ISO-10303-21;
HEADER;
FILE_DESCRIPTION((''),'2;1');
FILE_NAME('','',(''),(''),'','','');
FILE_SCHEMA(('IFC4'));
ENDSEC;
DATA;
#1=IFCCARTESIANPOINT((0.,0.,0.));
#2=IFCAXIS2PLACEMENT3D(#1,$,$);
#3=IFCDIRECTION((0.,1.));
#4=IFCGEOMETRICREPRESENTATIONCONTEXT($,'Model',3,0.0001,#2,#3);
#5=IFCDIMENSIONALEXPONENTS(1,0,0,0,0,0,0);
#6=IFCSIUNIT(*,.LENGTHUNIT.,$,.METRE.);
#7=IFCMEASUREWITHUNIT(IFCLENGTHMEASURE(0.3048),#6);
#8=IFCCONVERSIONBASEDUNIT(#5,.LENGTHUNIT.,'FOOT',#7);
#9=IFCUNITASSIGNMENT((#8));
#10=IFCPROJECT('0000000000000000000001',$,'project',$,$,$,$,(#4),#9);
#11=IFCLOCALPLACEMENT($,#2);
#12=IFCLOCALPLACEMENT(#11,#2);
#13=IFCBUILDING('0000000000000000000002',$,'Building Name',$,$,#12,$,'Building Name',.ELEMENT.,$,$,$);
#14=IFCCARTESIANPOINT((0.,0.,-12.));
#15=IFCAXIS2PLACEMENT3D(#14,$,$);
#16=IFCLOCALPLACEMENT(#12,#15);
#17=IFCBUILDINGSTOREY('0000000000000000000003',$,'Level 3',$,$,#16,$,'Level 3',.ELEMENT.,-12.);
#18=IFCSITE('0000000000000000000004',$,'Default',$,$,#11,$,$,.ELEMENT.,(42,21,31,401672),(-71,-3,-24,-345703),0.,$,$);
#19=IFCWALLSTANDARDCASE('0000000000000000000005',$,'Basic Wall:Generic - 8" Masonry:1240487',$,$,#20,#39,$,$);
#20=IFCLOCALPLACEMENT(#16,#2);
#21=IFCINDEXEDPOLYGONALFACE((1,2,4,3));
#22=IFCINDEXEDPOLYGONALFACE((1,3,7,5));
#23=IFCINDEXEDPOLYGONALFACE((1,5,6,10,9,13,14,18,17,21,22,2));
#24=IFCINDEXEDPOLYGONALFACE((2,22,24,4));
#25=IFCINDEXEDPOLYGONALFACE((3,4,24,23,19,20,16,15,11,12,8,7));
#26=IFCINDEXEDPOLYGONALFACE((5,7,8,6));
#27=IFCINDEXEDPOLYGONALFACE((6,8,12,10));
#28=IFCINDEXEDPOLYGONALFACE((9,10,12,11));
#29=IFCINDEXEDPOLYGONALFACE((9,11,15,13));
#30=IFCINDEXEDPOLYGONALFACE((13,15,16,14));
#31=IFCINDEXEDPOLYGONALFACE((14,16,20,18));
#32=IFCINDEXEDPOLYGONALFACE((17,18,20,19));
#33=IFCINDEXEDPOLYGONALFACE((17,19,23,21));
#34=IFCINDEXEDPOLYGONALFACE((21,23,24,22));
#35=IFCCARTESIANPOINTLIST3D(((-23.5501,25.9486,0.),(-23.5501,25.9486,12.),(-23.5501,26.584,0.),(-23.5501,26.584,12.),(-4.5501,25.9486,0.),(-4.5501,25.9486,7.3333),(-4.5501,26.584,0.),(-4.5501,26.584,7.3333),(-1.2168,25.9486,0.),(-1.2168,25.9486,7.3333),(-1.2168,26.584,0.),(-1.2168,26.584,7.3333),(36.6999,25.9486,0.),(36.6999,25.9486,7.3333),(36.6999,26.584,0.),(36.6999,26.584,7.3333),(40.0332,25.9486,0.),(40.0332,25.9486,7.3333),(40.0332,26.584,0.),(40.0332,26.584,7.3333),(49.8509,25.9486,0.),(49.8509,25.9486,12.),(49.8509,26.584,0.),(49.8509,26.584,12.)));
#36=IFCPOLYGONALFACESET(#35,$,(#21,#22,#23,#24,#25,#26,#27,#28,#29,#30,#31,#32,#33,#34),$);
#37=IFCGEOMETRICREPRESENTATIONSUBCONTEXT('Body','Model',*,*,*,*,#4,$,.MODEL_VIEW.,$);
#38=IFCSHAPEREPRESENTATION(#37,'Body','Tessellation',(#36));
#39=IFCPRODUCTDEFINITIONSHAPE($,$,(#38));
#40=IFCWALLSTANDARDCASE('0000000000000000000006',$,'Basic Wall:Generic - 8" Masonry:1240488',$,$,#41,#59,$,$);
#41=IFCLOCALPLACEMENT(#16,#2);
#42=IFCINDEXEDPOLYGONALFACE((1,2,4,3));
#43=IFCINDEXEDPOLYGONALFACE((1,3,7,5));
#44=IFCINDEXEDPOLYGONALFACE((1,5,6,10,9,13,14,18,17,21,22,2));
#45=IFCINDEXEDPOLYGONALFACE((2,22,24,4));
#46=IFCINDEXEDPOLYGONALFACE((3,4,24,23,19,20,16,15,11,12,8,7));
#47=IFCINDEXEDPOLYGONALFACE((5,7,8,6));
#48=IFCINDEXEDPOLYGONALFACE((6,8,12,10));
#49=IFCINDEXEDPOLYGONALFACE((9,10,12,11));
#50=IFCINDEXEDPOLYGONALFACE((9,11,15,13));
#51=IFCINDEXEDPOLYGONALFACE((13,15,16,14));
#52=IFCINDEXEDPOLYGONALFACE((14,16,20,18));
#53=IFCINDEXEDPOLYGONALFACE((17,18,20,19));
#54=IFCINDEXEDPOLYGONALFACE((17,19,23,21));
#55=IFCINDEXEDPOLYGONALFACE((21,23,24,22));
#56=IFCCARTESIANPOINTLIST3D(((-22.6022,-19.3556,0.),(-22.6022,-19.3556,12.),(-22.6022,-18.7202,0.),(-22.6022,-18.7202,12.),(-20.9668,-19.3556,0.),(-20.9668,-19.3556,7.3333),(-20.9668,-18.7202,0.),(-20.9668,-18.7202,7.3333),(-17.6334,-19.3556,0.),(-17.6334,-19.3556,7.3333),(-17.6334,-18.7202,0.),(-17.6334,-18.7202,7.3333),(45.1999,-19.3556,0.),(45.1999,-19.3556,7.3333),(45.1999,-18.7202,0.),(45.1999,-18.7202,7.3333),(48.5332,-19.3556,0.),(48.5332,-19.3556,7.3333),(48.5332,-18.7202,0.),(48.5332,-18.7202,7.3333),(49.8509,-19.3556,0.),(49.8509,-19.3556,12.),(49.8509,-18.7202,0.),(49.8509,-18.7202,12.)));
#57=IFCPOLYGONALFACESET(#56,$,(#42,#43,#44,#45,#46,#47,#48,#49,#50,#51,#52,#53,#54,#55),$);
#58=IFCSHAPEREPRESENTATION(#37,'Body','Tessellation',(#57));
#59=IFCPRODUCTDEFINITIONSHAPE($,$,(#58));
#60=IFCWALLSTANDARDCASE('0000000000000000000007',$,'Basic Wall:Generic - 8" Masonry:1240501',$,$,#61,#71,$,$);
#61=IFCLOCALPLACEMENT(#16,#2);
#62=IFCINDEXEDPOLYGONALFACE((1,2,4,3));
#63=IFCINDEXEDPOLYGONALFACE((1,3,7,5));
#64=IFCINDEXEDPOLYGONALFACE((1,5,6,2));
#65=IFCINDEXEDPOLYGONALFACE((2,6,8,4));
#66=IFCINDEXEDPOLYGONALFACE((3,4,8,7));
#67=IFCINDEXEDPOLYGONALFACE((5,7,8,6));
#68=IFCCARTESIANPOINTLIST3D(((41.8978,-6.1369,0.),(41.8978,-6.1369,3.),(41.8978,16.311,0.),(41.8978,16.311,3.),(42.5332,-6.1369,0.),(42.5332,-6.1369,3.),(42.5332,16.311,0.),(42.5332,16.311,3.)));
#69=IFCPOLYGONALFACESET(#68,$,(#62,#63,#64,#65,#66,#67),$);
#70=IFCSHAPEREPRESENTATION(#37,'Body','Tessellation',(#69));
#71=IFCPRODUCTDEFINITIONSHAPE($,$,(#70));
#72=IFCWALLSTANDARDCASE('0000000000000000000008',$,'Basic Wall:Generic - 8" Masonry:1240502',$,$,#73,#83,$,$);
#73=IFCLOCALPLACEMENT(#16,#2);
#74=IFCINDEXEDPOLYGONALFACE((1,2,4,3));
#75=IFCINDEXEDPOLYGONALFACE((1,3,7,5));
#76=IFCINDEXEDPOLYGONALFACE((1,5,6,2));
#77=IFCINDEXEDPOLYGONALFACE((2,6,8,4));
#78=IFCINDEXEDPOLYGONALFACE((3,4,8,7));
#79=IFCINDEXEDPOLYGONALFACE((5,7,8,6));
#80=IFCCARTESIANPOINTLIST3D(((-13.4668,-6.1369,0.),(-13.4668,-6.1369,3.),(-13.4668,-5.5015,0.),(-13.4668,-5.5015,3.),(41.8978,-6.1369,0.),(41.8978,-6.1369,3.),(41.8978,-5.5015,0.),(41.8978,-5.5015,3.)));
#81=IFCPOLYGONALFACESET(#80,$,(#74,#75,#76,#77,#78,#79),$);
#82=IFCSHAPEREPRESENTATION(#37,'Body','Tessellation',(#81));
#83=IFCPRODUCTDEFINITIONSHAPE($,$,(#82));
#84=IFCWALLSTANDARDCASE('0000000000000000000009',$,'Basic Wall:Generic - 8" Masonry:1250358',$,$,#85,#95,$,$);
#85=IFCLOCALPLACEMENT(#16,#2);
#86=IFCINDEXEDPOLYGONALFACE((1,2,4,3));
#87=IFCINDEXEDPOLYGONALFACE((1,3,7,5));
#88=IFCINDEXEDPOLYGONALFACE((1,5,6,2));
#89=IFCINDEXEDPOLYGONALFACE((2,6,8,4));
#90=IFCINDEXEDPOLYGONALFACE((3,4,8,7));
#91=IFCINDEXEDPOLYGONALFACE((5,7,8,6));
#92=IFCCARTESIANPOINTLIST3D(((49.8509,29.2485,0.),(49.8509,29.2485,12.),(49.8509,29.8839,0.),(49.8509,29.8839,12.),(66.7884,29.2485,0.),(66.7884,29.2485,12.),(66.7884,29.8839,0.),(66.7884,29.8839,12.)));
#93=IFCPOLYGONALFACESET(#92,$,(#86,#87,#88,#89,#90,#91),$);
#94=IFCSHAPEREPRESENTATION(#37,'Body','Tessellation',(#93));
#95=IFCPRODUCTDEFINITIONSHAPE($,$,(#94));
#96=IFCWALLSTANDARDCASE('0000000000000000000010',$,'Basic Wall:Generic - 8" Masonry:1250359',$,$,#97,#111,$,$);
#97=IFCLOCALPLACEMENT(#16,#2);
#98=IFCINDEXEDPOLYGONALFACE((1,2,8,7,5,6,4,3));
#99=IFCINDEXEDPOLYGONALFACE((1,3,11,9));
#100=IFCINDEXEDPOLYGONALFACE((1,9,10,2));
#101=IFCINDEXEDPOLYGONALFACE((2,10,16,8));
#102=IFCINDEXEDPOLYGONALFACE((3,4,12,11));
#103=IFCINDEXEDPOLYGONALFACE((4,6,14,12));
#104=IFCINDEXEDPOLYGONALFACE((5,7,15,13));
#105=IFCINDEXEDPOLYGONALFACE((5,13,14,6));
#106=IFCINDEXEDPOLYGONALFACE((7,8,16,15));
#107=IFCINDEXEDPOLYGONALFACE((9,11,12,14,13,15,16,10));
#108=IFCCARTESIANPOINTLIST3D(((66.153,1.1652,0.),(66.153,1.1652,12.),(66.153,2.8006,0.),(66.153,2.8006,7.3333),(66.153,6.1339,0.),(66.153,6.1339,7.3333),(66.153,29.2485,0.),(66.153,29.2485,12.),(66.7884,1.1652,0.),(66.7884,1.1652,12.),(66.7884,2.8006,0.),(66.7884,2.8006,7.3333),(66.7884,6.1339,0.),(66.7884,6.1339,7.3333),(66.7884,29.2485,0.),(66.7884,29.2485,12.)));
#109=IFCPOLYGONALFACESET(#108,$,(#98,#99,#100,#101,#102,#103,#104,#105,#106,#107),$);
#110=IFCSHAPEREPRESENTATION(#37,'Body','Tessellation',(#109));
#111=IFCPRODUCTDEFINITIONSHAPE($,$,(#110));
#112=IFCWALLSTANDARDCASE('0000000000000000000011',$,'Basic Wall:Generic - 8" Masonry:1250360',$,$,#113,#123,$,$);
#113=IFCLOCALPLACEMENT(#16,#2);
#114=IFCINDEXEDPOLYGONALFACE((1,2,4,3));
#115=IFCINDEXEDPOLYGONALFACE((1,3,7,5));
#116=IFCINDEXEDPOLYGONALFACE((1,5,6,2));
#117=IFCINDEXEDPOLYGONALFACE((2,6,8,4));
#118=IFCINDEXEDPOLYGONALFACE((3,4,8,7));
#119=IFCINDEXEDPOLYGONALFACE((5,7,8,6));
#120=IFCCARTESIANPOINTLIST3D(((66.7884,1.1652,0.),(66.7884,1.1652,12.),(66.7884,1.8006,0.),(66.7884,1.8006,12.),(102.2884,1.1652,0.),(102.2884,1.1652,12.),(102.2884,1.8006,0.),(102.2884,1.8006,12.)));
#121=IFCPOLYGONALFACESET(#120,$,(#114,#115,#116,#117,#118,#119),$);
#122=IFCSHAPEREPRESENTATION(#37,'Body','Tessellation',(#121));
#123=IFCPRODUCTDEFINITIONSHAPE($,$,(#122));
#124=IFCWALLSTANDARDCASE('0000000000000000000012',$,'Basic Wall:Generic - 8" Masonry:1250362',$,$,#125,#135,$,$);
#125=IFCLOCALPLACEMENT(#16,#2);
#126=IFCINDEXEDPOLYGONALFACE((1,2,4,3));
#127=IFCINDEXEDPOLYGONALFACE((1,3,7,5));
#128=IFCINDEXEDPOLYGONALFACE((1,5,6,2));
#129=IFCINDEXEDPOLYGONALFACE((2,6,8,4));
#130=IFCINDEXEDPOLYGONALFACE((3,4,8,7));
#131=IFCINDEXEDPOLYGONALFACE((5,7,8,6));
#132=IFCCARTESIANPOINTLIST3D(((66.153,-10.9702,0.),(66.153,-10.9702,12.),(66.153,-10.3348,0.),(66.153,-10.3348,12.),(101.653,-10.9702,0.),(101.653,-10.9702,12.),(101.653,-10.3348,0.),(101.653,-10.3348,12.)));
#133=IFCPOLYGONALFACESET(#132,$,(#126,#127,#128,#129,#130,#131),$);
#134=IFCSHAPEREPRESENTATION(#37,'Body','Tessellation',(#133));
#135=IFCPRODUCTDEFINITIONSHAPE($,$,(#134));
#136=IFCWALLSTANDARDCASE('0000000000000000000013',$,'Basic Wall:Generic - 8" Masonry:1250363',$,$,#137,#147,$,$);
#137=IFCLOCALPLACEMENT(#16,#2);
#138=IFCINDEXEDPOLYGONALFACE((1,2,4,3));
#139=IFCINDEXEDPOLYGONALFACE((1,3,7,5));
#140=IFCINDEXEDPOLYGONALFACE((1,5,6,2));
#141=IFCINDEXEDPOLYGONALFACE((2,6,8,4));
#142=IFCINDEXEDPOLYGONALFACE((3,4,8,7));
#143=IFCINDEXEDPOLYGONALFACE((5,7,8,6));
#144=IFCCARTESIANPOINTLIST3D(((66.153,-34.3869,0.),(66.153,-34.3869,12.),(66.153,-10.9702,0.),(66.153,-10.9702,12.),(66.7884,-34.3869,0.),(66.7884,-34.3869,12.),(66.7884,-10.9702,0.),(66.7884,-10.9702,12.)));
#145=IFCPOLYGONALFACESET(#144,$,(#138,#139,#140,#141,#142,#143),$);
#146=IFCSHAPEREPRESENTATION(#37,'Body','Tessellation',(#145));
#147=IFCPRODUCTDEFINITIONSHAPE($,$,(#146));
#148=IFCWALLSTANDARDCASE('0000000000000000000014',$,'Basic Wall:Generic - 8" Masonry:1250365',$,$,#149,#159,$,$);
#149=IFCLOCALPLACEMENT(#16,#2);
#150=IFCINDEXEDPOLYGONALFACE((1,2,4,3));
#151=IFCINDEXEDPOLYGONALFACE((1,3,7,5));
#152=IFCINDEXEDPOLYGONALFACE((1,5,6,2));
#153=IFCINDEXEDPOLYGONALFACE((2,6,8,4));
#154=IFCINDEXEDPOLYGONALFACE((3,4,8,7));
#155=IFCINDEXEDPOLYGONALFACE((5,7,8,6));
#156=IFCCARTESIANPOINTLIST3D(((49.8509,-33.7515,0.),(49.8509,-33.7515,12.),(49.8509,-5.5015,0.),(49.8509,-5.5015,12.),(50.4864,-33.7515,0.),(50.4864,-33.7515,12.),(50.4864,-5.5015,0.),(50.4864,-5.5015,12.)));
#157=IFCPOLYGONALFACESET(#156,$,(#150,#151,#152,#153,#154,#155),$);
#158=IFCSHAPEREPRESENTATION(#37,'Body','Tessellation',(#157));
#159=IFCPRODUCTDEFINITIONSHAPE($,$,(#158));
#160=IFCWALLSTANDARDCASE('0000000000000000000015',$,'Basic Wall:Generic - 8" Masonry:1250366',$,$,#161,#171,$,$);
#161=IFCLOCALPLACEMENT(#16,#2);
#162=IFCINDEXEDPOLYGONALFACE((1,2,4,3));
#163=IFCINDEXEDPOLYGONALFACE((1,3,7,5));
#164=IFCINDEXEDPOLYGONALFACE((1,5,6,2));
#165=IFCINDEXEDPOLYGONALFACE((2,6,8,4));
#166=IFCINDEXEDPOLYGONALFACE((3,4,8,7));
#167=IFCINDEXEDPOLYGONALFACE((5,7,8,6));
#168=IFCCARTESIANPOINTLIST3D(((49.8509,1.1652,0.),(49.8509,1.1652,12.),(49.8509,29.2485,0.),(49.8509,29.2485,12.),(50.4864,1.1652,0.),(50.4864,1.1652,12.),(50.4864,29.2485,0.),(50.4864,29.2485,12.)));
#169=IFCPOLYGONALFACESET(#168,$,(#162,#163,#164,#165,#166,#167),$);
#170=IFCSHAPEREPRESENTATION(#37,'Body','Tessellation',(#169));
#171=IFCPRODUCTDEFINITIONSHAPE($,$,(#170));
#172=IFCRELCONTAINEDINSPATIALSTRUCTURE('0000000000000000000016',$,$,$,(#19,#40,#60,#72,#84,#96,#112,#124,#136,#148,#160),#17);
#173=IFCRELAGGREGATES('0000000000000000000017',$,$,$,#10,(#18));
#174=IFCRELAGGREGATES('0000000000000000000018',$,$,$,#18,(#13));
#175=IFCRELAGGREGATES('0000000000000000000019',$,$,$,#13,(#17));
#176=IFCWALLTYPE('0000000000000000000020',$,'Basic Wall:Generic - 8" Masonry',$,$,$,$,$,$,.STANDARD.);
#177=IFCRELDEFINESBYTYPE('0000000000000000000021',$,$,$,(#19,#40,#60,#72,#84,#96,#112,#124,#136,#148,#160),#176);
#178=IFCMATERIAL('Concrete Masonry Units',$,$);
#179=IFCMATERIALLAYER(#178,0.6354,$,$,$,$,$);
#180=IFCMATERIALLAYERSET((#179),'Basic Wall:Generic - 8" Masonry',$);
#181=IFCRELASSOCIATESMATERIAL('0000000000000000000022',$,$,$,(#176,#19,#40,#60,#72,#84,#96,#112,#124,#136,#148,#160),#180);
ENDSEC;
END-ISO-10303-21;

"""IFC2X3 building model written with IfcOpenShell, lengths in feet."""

from ifc_helpers import new_model, entity, si_unit, converted_unit, direction, frame, frame_2d, origin, place, context, subcontext, project, spatial, rectangle, extrude, material, layer, layer_set, layer_usage, type_object, element, save


model = new_model("IFC2X3")

# Units and contexts
model_context = context("Model", 3, precision=0.0001, world=origin(), true_north=direction((0.0, 1.0)))
body_context = subcontext(model_context, "Body", "Model", "MODEL_VIEW")
ifc_project = project(units=[converted_unit("LENGTHUNIT", "FOOT", entity("IfcLengthMeasure", 0.3048), si_unit("LENGTHUNIT", "METRE"), dimensions=[1, 0, 0, 0, 0, 0, 0])], contexts=[model_context])

# Site, building, storey
site_placement = place(None, origin())
site = spatial("IfcSite", under=ifc_project, at=site_placement, Name="Default", CompositionType="ELEMENT", RefLatitude=(42, 21, 31, 401672), RefLongitude=(-71, -3, -24, -345703), RefElevation=0.0)
building_placement = place(site_placement, origin())
building = spatial("IfcBuilding", under=site, at=building_placement, Name="Building Name", LongName="Building Name", CompositionType="ELEMENT")
storey_placement = place(building_placement, frame((0.0, 0.0, -12.0)))
storey = spatial("IfcBuildingStorey", under=building, at=storey_placement, Name="Level 3", LongName="Level 3", CompositionType="ELEMENT", Elevation=-12.0)

# Walls, openings
ifc_material_1 = material(Name="Concrete Masonry Units")
ifc_layer_1 = layer(ifc_material_1, 0.6354)
ifc_layer_set_1 = layer_set([ifc_layer_1], Name="Basic Wall:Generic - 8\" Masonry")
ifc_layer_usage_1 = layer_usage(ifc_layer_set_1, "AXIS2", "NEGATIVE", 0.3177)
wall_type_1 = type_object("IfcWallType", Name="Basic Wall:Generic - 8\" Masonry", PredefinedType="STANDARD", material=ifc_layer_set_1)
wall_1_placement = place(storey_placement, frame((49.8509, 26.2663, 0.0), z_axis=(0.0, 0.0, 1.0), x_axis=(-1.0, 0.0, 0.0)))
wall_1 = element("IfcWallStandardCase", 1, at=wall_1_placement, inside=storey, type_object=wall_type_1, material=ifc_layer_usage_1, Name="Basic Wall:Generic - 8\" Masonry:1240487", context=body_context, shape_type="SweptSolid", body=[
    extrude(rectangle(XDim=73.401, YDim=0.6354, at=frame_2d((36.7005, 0.0), x_axis=(1.0, 0.0))), origin(), (0.0, 0.0, 1.0), 12.0),
])
opening_1_placement = place(wall_1_placement, frame((13.151, 0.3177, 0.0)))
element("IfcOpeningElement", 2, at=opening_1_placement, cuts=wall_1, ObjectType="Opening", context=body_context, shape_type="SweptSolid", body=[
    extrude(rectangle(XDim=7.3333, YDim=3.3333, at=frame_2d((3.6667, 1.6667), x_axis=(1.0, 0.0))), frame((0.0, 0.0, 0.0), z_axis=(0.0, -1.0, 0.0), x_axis=(0.0, 0.0, 1.0)), (0.0, 0.0, 1.0), 0.6354),
])
opening_2_placement = place(wall_1_placement, frame((54.401, 0.3177, 0.0)))
element("IfcOpeningElement", 3, at=opening_2_placement, cuts=wall_1, ObjectType="Opening", context=body_context, shape_type="SweptSolid", body=[
    extrude(rectangle(XDim=7.3333, YDim=3.3333, at=frame_2d((3.6667, 1.6667), x_axis=(1.0, 0.0))), frame((0.0, 0.0, 0.0), z_axis=(0.0, -1.0, 0.0), x_axis=(0.0, 0.0, 1.0)), (0.0, 0.0, 1.0), 0.6354),
])
ifc_layer_usage_2 = layer_usage(ifc_layer_set_1, "AXIS2", "NEGATIVE", 0.3177)
wall_2_placement = place(storey_placement, frame((49.8509, -19.0379, 0.0), z_axis=(0.0, 0.0, 1.0), x_axis=(-1.0, 0.0, 0.0)))
wall_2 = element("IfcWallStandardCase", 4, at=wall_2_placement, inside=storey, type_object=wall_type_1, material=ifc_layer_usage_2, Name="Basic Wall:Generic - 8\" Masonry:1240488", context=body_context, shape_type="SweptSolid", body=[
    extrude(rectangle(XDim=72.4531, YDim=0.6354, at=frame_2d((36.2266, 0.0), x_axis=(1.0, 0.0))), origin(), (0.0, 0.0, 1.0), 12.0),
])
opening_3_placement = place(wall_2_placement, frame((1.3177, -0.3177, 0.0)))
element("IfcOpeningElement", 5, at=opening_3_placement, cuts=wall_2, ObjectType="Opening", context=body_context, shape_type="SweptSolid", body=[
    extrude(rectangle(XDim=7.3333, YDim=3.3333, at=frame_2d((3.6667, 1.6667), x_axis=(1.0, 0.0))), frame((0.0, 0.0, 0.0), z_axis=(0.0, 1.0, 0.0), x_axis=(0.0, 0.0, 1.0)), (0.0, 0.0, 1.0), 0.6354),
])
opening_4_placement = place(wall_2_placement, frame((67.4844, -0.3177, 0.0)))
element("IfcOpeningElement", 6, at=opening_4_placement, cuts=wall_2, ObjectType="Opening", context=body_context, shape_type="SweptSolid", body=[
    extrude(rectangle(XDim=7.3333, YDim=3.3333, at=frame_2d((3.6667, 1.6667), x_axis=(1.0, 0.0))), frame((0.0, 0.0, 0.0), z_axis=(0.0, 1.0, 0.0), x_axis=(0.0, 0.0, 1.0)), (0.0, 0.0, 1.0), 0.6354),
])

# Walls
ifc_layer_usage_3 = layer_usage(ifc_layer_set_1, "AXIS2", "NEGATIVE", 0.3177)
wall_3_placement = place(storey_placement, frame((42.2155, 16.311, 0.0), z_axis=(0.0, 0.0, 1.0), x_axis=(0.0, -1.0, 0.0)))
element("IfcWallStandardCase", 7, at=wall_3_placement, inside=storey, type_object=wall_type_1, material=ifc_layer_usage_3, Name="Basic Wall:Generic - 8\" Masonry:1240501", context=body_context, shape_type="SweptSolid", body=[
    extrude(rectangle(XDim=22.4479, YDim=0.6354, at=frame_2d((11.224, 0.0), x_axis=(-1.0, 0.0))), origin(), (0.0, 0.0, 1.0), 3.0),
])
ifc_layer_usage_4 = layer_usage(ifc_layer_set_1, "AXIS2", "NEGATIVE", 0.3177)
wall_4_placement = place(storey_placement, frame((41.8978, -5.8192, 0.0), z_axis=(0.0, 0.0, 1.0), x_axis=(-1.0, 0.0, 0.0)))
element("IfcWallStandardCase", 8, at=wall_4_placement, inside=storey, type_object=wall_type_1, material=ifc_layer_usage_4, Name="Basic Wall:Generic - 8\" Masonry:1240502", context=body_context, shape_type="SweptSolid", body=[
    extrude(rectangle(XDim=55.3646, YDim=0.6354, at=frame_2d((27.6823, 0.0), x_axis=(-1.0, 0.0))), origin(), (0.0, 0.0, 1.0), 3.0),
])
ifc_layer_usage_5 = layer_usage(ifc_layer_set_1, "AXIS2", "NEGATIVE", 0.3177)
wall_5_placement = place(storey_placement, frame((49.8509, 29.5662, 0.0)))
element("IfcWallStandardCase", 9, at=wall_5_placement, inside=storey, type_object=wall_type_1, material=ifc_layer_usage_5, Name="Basic Wall:Generic - 8\" Masonry:1250358", context=body_context, shape_type="SweptSolid", body=[
    extrude(rectangle(XDim=16.9375, YDim=0.6354, at=frame_2d((8.4688, 0.0), x_axis=(-1.0, 0.0))), origin(), (0.0, 0.0, 1.0), 12.0),
])

# Wall, opening
ifc_layer_usage_6 = layer_usage(ifc_layer_set_1, "AXIS2", "NEGATIVE", 0.3177)
wall_6_placement = place(storey_placement, frame((66.4707, 29.2485, 0.0), z_axis=(0.0, 0.0, 1.0), x_axis=(0.0, -1.0, 0.0)))
wall_6 = element("IfcWallStandardCase", 10, at=wall_6_placement, inside=storey, type_object=wall_type_1, material=ifc_layer_usage_6, Name="Basic Wall:Generic - 8\" Masonry:1250359", context=body_context, shape_type="SweptSolid", body=[
    extrude(rectangle(XDim=28.0833, YDim=0.6354, at=frame_2d((14.0417, 0.0), x_axis=(1.0, 0.0))), origin(), (0.0, 0.0, 1.0), 12.0),
])
opening_5_placement = place(wall_6_placement, frame((23.1146, -0.3177, 0.0)))
element("IfcOpeningElement", 11, at=opening_5_placement, cuts=wall_6, ObjectType="Opening", context=body_context, shape_type="SweptSolid", body=[
    extrude(rectangle(XDim=7.3333, YDim=3.3333, at=frame_2d((3.6667, 1.6667), x_axis=(1.0, 0.0))), frame((0.0, 0.0, 0.0), z_axis=(0.0, 1.0, 0.0), x_axis=(0.0, 0.0, 1.0)), (0.0, 0.0, 1.0), 0.6354),
])

# Wall
ifc_layer_usage_7 = layer_usage(ifc_layer_set_1, "AXIS2", "NEGATIVE", 0.3177)
wall_7_placement = place(storey_placement, frame((66.7884, 1.4829, 0.0)))
element("IfcWallStandardCase", 12, at=wall_7_placement, inside=storey, type_object=wall_type_1, material=ifc_layer_usage_7, Name="Basic Wall:Generic - 8\" Masonry:1250360", context=body_context, shape_type="SweptSolid", body=[
    extrude(rectangle(XDim=35.5, YDim=0.6354, at=frame_2d((17.75, 0.0), x_axis=(-1.0, 0.0))), origin(), (0.0, 0.0, 1.0), 12.0),
])

# Walls
ifc_layer_usage_8 = layer_usage(ifc_layer_set_1, "AXIS2", "NEGATIVE", 0.3177)
wall_8_placement = place(storey_placement, frame((101.653, -10.6525, 0.0), z_axis=(0.0, 0.0, 1.0), x_axis=(-1.0, 0.0, 0.0)))
element("IfcWallStandardCase", 13, at=wall_8_placement, inside=storey, type_object=wall_type_1, material=ifc_layer_usage_8, Name="Basic Wall:Generic - 8\" Masonry:1250362", context=body_context, shape_type="SweptSolid", body=[
    extrude(rectangle(XDim=35.5, YDim=0.6354, at=frame_2d((17.75, 0.0), x_axis=(-1.0, 0.0))), origin(), (0.0, 0.0, 1.0), 12.0),
])
ifc_layer_usage_9 = layer_usage(ifc_layer_set_1, "AXIS2", "NEGATIVE", 0.3177)
wall_9_placement = place(storey_placement, frame((66.4707, -10.9702, 0.0), z_axis=(0.0, 0.0, 1.0), x_axis=(0.0, -1.0, 0.0)))
element("IfcWallStandardCase", 14, at=wall_9_placement, inside=storey, type_object=wall_type_1, material=ifc_layer_usage_9, Name="Basic Wall:Generic - 8\" Masonry:1250363", context=body_context, shape_type="SweptSolid", body=[
    extrude(rectangle(XDim=23.4167, YDim=0.6354, at=frame_2d((11.7083, 0.0), x_axis=(-1.0, 0.0))), origin(), (0.0, 0.0, 1.0), 12.0),
])

# Walls
ifc_layer_usage_10 = layer_usage(ifc_layer_set_1, "AXIS2", "NEGATIVE", 0.3177)
wall_10_placement = place(storey_placement, frame((50.1686, -33.7515, 0.0), z_axis=(0.0, 0.0, 1.0), x_axis=(0.0, 1.0, 0.0)))
element("IfcWallStandardCase", 15, at=wall_10_placement, inside=storey, type_object=wall_type_1, material=ifc_layer_usage_10, Name="Basic Wall:Generic - 8\" Masonry:1250365", context=body_context, shape_type="SweptSolid", body=[
    extrude(rectangle(XDim=28.25, YDim=0.6354, at=frame_2d((14.125, 0.0), x_axis=(-1.0, 0.0))), origin(), (0.0, 0.0, 1.0), 12.0),
])
ifc_layer_usage_11 = layer_usage(ifc_layer_set_1, "AXIS2", "NEGATIVE", 0.3177)
wall_11_placement = place(storey_placement, frame((50.1686, 29.2485, 0.0), z_axis=(0.0, 0.0, 1.0), x_axis=(0.0, -1.0, 0.0)))
element("IfcWallStandardCase", 16, at=wall_11_placement, inside=storey, type_object=wall_type_1, material=ifc_layer_usage_11, Name="Basic Wall:Generic - 8\" Masonry:1250366", context=body_context, shape_type="SweptSolid", body=[
    extrude(rectangle(XDim=28.0833, YDim=0.6354, at=frame_2d((14.0417, 0.0), x_axis=(-1.0, 0.0))), origin(), (0.0, 0.0, 1.0), 12.0),
])

save(model, "model.ifc")
